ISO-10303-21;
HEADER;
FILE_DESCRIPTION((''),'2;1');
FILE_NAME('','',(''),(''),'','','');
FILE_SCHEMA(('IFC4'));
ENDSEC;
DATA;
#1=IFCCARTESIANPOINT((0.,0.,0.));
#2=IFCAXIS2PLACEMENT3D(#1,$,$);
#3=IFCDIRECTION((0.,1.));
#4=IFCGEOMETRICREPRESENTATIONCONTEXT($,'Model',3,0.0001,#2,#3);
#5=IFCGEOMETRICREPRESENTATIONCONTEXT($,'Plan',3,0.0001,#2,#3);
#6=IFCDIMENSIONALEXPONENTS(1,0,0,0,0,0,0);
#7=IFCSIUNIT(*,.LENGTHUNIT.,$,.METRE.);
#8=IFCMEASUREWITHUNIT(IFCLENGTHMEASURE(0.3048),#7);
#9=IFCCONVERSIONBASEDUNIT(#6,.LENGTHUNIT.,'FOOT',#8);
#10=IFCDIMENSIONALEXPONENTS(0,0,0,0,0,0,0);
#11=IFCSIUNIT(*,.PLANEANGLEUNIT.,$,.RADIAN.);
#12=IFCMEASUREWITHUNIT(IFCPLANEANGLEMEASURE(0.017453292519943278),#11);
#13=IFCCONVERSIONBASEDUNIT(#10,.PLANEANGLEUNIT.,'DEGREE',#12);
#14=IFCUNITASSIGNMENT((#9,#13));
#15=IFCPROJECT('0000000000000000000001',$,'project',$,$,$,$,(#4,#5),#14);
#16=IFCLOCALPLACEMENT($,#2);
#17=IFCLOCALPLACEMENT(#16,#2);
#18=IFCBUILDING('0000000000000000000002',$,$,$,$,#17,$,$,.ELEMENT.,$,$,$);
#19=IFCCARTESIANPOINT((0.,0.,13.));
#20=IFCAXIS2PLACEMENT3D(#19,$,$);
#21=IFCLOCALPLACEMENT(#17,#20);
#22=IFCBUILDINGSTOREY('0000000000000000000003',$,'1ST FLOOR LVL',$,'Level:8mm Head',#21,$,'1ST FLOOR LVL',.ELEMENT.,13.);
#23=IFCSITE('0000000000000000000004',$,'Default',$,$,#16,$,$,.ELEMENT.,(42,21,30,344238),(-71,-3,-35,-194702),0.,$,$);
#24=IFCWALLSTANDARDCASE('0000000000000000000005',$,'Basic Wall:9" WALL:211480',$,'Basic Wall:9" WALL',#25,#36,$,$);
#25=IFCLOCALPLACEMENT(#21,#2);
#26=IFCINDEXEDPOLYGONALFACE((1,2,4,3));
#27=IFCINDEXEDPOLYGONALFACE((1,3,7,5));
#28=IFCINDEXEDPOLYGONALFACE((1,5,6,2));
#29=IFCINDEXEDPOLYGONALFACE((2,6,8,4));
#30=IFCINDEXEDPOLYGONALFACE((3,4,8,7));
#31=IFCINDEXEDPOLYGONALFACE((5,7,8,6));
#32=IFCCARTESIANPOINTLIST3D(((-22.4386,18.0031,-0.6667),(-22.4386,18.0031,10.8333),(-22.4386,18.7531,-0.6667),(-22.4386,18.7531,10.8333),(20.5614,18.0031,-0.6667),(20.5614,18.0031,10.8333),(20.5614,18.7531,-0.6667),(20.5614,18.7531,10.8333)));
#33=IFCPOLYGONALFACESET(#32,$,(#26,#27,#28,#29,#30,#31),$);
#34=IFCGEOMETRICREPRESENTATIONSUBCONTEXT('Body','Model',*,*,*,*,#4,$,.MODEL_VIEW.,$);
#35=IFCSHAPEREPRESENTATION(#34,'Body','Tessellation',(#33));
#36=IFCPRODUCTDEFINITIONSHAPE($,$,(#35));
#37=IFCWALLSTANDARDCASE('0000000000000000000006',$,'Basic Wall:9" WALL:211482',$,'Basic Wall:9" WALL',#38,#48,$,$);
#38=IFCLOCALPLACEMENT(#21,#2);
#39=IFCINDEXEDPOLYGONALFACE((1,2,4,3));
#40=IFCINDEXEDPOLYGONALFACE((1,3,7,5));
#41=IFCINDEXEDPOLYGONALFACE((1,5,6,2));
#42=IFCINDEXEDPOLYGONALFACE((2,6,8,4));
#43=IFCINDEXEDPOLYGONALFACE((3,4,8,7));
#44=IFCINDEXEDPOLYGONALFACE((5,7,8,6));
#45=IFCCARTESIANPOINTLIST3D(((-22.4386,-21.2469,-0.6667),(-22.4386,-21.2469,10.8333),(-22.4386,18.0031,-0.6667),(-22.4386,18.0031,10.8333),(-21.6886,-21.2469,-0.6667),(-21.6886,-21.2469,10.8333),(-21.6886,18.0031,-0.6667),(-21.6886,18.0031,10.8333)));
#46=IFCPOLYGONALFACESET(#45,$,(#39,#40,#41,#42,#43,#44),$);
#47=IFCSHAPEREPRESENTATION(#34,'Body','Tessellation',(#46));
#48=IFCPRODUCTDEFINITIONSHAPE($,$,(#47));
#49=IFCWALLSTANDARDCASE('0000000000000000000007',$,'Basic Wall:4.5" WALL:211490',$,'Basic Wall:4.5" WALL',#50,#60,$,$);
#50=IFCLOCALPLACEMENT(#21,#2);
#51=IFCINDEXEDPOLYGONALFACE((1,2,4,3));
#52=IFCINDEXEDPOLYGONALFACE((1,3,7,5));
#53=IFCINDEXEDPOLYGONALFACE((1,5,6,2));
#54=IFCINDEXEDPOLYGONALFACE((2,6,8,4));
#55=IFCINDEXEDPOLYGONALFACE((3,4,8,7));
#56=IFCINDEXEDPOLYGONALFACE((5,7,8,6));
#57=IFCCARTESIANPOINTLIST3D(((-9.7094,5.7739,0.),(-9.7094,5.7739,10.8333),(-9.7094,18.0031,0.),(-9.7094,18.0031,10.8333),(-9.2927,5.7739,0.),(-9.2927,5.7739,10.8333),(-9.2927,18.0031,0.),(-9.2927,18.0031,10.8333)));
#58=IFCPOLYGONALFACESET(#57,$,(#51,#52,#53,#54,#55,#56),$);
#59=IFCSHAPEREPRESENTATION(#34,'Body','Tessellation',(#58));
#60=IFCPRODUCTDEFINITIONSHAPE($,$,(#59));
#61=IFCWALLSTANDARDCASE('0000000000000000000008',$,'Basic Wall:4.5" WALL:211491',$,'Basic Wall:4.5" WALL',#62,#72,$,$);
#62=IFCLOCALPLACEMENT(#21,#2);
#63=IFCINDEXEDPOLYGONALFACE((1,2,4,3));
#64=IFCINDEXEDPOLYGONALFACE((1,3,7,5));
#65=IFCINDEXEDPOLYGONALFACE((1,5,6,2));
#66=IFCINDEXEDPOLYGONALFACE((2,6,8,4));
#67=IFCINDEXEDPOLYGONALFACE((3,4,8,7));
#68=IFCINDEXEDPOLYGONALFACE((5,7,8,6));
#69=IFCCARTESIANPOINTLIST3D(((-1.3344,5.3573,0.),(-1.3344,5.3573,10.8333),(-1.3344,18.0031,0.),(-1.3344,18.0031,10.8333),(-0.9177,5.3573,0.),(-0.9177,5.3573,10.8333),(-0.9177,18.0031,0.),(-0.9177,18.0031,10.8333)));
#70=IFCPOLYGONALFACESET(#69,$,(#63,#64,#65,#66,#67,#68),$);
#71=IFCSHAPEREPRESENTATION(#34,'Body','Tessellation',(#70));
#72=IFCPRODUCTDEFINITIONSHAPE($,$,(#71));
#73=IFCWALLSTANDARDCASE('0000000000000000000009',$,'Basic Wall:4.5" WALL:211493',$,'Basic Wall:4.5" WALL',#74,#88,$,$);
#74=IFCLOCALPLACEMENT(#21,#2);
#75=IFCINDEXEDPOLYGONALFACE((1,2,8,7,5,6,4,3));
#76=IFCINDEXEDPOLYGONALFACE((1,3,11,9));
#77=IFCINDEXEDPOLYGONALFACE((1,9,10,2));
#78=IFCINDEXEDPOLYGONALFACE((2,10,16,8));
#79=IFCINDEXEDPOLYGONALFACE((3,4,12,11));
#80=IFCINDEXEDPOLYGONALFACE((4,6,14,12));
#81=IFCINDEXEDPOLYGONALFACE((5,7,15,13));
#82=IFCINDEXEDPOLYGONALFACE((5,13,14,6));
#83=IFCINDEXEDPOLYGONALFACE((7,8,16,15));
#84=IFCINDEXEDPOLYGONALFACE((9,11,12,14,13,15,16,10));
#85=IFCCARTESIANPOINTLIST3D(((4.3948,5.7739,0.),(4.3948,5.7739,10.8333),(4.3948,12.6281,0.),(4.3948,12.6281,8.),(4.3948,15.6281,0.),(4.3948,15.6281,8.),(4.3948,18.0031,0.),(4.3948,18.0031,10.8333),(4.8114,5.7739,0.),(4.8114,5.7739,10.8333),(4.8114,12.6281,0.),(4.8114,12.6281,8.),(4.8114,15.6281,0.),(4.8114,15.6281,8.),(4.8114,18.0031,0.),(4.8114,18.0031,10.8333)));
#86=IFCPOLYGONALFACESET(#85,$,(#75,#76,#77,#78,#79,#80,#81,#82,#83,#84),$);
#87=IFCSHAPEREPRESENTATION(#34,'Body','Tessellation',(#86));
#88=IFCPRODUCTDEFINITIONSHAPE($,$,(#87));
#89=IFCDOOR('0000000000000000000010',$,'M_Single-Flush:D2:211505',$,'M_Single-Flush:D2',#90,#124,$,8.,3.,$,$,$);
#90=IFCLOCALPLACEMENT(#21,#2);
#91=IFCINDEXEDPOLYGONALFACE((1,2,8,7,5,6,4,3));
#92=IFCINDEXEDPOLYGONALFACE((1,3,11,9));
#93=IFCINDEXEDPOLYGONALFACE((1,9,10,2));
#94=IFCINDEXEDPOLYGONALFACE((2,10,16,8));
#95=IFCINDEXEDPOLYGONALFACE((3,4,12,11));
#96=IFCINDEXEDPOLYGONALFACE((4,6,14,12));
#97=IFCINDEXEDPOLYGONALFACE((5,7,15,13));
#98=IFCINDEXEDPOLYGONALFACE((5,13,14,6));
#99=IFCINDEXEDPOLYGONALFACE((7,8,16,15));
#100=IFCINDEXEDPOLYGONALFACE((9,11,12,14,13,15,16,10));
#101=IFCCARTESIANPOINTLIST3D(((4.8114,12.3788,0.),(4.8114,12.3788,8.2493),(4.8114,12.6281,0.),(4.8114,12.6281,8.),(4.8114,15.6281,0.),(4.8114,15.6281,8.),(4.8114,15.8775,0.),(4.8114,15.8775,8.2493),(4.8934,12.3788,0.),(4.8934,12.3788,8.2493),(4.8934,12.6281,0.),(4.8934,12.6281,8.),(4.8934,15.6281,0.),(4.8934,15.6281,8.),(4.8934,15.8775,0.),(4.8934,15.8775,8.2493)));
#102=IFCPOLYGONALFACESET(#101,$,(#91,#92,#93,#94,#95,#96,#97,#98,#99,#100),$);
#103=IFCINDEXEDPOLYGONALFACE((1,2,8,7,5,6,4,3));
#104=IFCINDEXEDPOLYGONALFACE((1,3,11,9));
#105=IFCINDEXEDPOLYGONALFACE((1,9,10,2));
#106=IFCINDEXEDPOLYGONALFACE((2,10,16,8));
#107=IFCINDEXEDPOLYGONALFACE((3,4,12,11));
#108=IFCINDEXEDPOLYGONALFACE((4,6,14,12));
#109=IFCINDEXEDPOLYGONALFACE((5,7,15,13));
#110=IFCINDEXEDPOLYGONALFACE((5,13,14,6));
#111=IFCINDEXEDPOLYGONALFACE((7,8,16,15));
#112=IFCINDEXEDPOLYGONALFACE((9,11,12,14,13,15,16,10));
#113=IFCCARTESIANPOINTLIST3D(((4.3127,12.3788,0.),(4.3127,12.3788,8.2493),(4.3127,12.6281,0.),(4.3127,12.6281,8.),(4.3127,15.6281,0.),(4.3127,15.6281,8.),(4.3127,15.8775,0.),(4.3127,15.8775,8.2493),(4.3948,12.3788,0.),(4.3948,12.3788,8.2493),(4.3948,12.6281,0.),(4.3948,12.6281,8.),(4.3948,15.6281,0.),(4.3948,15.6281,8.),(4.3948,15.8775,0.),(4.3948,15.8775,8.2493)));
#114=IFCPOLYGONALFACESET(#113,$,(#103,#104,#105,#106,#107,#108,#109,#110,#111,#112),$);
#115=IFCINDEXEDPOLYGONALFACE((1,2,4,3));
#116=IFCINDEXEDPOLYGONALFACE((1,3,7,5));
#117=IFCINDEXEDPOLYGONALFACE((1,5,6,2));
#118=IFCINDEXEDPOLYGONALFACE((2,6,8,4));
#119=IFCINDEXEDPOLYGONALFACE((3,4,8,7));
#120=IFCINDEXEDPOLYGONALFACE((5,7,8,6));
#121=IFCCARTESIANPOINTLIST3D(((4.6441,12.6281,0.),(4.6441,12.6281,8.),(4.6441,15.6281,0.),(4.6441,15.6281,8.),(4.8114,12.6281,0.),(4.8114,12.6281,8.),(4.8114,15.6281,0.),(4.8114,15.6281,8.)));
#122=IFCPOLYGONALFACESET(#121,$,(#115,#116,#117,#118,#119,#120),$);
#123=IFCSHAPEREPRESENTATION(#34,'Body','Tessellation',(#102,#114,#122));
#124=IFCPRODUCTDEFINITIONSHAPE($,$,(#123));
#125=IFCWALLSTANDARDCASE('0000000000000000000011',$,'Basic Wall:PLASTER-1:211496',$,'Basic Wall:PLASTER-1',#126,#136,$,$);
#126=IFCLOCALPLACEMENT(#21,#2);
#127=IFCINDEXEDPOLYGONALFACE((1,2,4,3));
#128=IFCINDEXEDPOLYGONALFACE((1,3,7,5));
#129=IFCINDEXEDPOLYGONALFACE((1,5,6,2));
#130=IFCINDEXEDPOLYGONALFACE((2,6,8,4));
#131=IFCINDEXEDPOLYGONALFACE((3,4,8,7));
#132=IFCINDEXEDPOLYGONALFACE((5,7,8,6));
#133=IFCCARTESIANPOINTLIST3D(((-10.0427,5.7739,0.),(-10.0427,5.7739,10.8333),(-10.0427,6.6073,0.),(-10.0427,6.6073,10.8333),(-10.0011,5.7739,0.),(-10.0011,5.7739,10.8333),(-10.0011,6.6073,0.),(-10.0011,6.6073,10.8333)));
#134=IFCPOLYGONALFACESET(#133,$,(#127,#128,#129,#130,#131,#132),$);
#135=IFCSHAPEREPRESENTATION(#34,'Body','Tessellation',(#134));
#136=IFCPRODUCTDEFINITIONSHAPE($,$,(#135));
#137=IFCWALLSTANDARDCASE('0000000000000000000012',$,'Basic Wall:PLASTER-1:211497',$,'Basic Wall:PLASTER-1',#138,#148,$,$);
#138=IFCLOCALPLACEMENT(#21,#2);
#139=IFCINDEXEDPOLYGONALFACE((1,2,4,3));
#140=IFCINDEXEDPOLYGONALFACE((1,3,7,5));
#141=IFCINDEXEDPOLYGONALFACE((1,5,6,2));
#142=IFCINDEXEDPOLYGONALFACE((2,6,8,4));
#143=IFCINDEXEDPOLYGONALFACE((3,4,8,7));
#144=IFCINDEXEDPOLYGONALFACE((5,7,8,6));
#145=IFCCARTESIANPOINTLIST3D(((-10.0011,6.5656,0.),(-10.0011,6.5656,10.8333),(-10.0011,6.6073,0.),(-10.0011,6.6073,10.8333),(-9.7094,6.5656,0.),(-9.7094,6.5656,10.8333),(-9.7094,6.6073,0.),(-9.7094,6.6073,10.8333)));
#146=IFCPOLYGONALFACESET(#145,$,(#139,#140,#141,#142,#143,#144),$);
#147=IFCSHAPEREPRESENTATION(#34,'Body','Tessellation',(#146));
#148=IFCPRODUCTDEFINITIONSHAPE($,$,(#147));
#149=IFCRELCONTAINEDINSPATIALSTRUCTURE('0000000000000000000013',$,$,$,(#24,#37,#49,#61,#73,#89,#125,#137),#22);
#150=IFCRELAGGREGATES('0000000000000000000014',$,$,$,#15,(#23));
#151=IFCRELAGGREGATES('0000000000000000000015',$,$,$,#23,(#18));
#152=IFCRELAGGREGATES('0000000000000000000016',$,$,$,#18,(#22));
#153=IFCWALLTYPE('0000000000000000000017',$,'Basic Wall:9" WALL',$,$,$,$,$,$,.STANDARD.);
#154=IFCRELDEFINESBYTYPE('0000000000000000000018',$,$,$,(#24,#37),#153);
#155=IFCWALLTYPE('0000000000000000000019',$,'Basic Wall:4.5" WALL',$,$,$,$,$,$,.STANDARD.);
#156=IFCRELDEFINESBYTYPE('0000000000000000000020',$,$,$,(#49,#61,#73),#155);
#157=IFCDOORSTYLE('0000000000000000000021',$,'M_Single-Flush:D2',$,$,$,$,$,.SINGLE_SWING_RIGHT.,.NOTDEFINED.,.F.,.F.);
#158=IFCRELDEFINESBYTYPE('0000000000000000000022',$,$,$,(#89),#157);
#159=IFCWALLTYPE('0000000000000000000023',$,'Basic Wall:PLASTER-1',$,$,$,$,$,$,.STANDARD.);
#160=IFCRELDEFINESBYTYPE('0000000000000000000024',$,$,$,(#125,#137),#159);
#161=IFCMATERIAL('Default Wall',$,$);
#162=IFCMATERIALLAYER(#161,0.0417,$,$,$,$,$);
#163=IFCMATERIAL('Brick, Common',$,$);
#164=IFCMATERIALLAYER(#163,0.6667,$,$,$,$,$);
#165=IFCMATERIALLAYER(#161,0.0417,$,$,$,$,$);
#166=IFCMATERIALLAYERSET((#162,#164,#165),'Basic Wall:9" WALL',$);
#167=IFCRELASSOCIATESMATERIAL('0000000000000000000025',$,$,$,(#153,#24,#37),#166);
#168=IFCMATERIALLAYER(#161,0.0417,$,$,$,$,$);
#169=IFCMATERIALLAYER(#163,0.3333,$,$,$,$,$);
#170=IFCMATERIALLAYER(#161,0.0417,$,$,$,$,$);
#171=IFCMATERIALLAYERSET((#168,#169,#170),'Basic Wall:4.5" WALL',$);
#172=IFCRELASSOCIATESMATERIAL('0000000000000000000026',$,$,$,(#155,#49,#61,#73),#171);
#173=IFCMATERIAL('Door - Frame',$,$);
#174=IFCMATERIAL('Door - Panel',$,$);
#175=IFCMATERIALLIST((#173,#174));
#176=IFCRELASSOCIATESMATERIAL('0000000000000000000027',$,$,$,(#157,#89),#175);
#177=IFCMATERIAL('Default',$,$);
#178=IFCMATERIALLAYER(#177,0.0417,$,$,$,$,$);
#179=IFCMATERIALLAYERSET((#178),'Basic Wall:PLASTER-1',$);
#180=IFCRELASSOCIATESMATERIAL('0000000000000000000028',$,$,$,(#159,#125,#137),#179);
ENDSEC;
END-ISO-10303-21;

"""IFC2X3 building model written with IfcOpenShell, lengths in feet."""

from ifc_helpers import new_model, entity, si_unit, converted_unit, direction, frame, frame_2d, origin, place, context, subcontext, project, spatial, polyline, rectangle, outline, extrude, source, transform, mapped, material, material_list, layer, layer_set, layer_usage, type_object, type_shapes, element, fill, save


model = new_model("IFC2X3")

# Units and contexts
model_context = context("Model", 3, precision=0.0001, world=origin(), true_north=direction((0.0, 1.0)))
plan_context = context("Plan", 3, precision=0.0001, world=origin(), true_north=direction((0.0, 1.0)))
body_context = subcontext(model_context, "Body", "Model", "MODEL_VIEW")
ifc_project = project(units=[converted_unit("LENGTHUNIT", "FOOT", entity("IfcLengthMeasure", 0.3048), si_unit("LENGTHUNIT", "METRE"), dimensions=[1, 0, 0, 0, 0, 0, 0]), converted_unit("PLANEANGLEUNIT", "DEGREE", entity("IfcPlaneAngleMeasure", 0.017453292519943278), si_unit("PLANEANGLEUNIT", "RADIAN"), dimensions=[0, 0, 0, 0, 0, 0, 0])], contexts=[model_context, plan_context])

# Site, building, storey
site_placement = place(None, origin())
site = spatial("IfcSite", under=ifc_project, at=site_placement, Name="Default", CompositionType="ELEMENT", RefLatitude=(42, 21, 30, 344238), RefLongitude=(-71, -3, -35, -194702), RefElevation=0.0)
building_placement = place(site_placement, origin())
building = spatial("IfcBuilding", under=site, at=building_placement, CompositionType="ELEMENT")
storey_placement = place(building_placement, frame((0.0, 0.0, 13.0)))
storey = spatial("IfcBuildingStorey", under=building, at=storey_placement, Name="1ST FLOOR LVL", ObjectType="Level:8mm Head", LongName="1ST FLOOR LVL", CompositionType="ELEMENT", Elevation=13.0)

# Wall
ifc_material_1 = material(Name="Default Wall")
ifc_layer_1 = layer(ifc_material_1, 0.0417)
ifc_material_2 = material(Name="Brick, Common")
ifc_layer_2 = layer(ifc_material_2, 0.6667)
ifc_layer_3 = layer(ifc_material_1, 0.0417)
ifc_layer_set_1 = layer_set([ifc_layer_1, ifc_layer_2, ifc_layer_3], Name="Basic Wall:9\" WALL")
ifc_layer_usage_1 = layer_usage(ifc_layer_set_1, "AXIS2", "NEGATIVE", 0.375)
wall_type_1 = type_object("IfcWallType", Name="Basic Wall:9\" WALL", PredefinedType="STANDARD", material=ifc_layer_set_1)
wall_1_placement = place(storey_placement, frame((-22.4386, 18.3781, -0.6667)))
element("IfcWallStandardCase", 1, at=wall_1_placement, inside=storey, type_object=wall_type_1, material=ifc_layer_usage_1, Name="Basic Wall:9\" WALL:211480", ObjectType="Basic Wall:9\" WALL", context=body_context, shape_type="SweptSolid", body=[
    extrude(rectangle(XDim=43.0, YDim=0.75, at=frame_2d((21.5, 0.0), x_axis=(-1.0, 0.0))), origin(), (0.0, 0.0, 1.0), 11.5),
])

# Wall
ifc_layer_usage_2 = layer_usage(ifc_layer_set_1, "AXIS2", "NEGATIVE", 0.375)
wall_2_placement = place(storey_placement, frame((-22.0636, 18.0031, -0.6667), z_axis=(0.0, 0.0, 1.0), x_axis=(0.0, -1.0, 0.0)))
element("IfcWallStandardCase", 2, at=wall_2_placement, inside=storey, type_object=wall_type_1, material=ifc_layer_usage_2, Name="Basic Wall:9\" WALL:211482", ObjectType="Basic Wall:9\" WALL", context=body_context, shape_type="SweptSolid", body=[
    extrude(rectangle(XDim=39.25, YDim=0.75, at=frame_2d((19.625, 0.0), x_axis=(-1.0, 0.0))), origin(), (0.0, 0.0, 1.0), 11.5),
])

# Shared definitions
ifc_layer_4 = layer(ifc_material_1, 0.0417)
ifc_layer_5 = layer(ifc_material_2, 0.3333)
ifc_layer_6 = layer(ifc_material_1, 0.0417)
ifc_layer_set_2 = layer_set([ifc_layer_4, ifc_layer_5, ifc_layer_6], Name="Basic Wall:4.5\" WALL")
wall_type_2 = type_object("IfcWallType", Name="Basic Wall:4.5\" WALL", PredefinedType="STANDARD", material=ifc_layer_set_2)
ifc_material_3 = material(Name="Door - Frame")
ifc_material_4 = material(Name="Door - Panel")
ifc_material_list_1 = material_list([ifc_material_3, ifc_material_4])

# Walls
ifc_layer_usage_3 = layer_usage(ifc_layer_set_2, "AXIS2", "NEGATIVE", 0.2083)
wall_3_placement = place(storey_placement, frame((-9.5011, 18.0031, 0.0), z_axis=(0.0, 0.0, 1.0), x_axis=(0.0, -1.0, 0.0)))
element("IfcWallStandardCase", 3, at=wall_3_placement, inside=storey, type_object=wall_type_2, material=ifc_layer_usage_3, Name="Basic Wall:4.5\" WALL:211490", ObjectType="Basic Wall:4.5\" WALL", context=body_context, shape_type="SweptSolid", body=[
    extrude(rectangle(XDim=12.2292, YDim=0.4167, at=frame_2d((6.1146, 0.0), x_axis=(-1.0, 0.0))), origin(), (0.0, 0.0, 1.0), 10.8333),
])
ifc_layer_usage_4 = layer_usage(ifc_layer_set_2, "AXIS2", "NEGATIVE", 0.2083)
wall_4_placement = place(storey_placement, frame((-1.1261, 18.0031, 0.0), z_axis=(0.0, 0.0, 1.0), x_axis=(0.0, -1.0, 0.0)))
element("IfcWallStandardCase", 4, at=wall_4_placement, inside=storey, type_object=wall_type_2, material=ifc_layer_usage_4, Name="Basic Wall:4.5\" WALL:211491", ObjectType="Basic Wall:4.5\" WALL", context=body_context, shape_type="SweptSolid", body=[
    extrude(rectangle(XDim=12.6458, YDim=0.4167, at=frame_2d((6.3229, 0.0), x_axis=(-1.0, 0.0))), origin(), (0.0, 0.0, 1.0), 10.8333),
])

# Wall, opening, door
ifc_layer_usage_5 = layer_usage(ifc_layer_set_2, "AXIS2", "NEGATIVE", 0.2083)
wall_5_placement = place(storey_placement, frame((4.6031, 5.7739, 0.0), z_axis=(0.0, 0.0, 1.0), x_axis=(0.0, 1.0, 0.0)))
wall_5 = element("IfcWallStandardCase", 5, at=wall_5_placement, inside=storey, type_object=wall_type_2, material=ifc_layer_usage_5, Name="Basic Wall:4.5\" WALL:211493", ObjectType="Basic Wall:4.5\" WALL", context=body_context, shape_type="SweptSolid", body=[
    extrude(rectangle(XDim=12.2292, YDim=0.4167, at=frame_2d((6.1146, 0.0), x_axis=(1.0, 0.0))), origin(), (0.0, 0.0, 1.0), 10.8333),
])
opening_1_placement = place(wall_5_placement, frame((9.8542, 0.2083, 0.0)))
opening_1 = element("IfcOpeningElement", 6, at=opening_1_placement, cuts=wall_5, ObjectType="Opening", context=body_context, shape_type="SweptSolid", body=[
    extrude(rectangle(XDim=3.0, YDim=8.0, at=frame_2d((4.0, 1.5), x_axis=(0.0, 1.0))), frame((0.0, 0.0, 0.0), z_axis=(0.0, -1.0, 0.0), x_axis=(0.0, 0.0, 1.0)), (0.0, 0.0, 1.0), 0.4167),
])
door_style_1 = type_object("IfcDoorStyle", Name="M_Single-Flush:D2", ConstructionType="NOTDEFINED", OperationType="SINGLE_SWING_RIGHT", ParameterTakesPrecedence=False, Sizeable=False, material=ifc_material_list_1)
shared_shape_1 = source(origin(), body_context, "Body", "SweptSolid", [
    extrude(outline(polyline([(-1.7493, -4.187), (1.7493, -4.187), (1.7493, 4.0623), (1.5, 4.0623), (1.5, -3.9377), (-1.5, -3.9377), (-1.5, 4.0623), (-1.7493, 4.0623), (-1.7493, -4.187)])), frame((1.5, 0.4167, 4.0623), z_axis=(0.0, 1.0, 0.0), x_axis=(1.0, 0.0, 0.0)), (0.0, 0.0, 1.0), 0.082),
    extrude(outline(polyline([(-4.187, -1.7493), (4.0623, -1.7493), (4.0623, -1.5), (-3.9377, -1.5), (-3.9377, 1.5), (4.0623, 1.5), (4.0623, 1.7493), (-4.187, 1.7493), (-4.187, -1.7493)])), frame((1.5, -0.082, 4.0623), z_axis=(0.0, 1.0, 0.0), x_axis=(0.0, 0.0, -1.0)), (0.0, 0.0, 1.0), 0.082),
    extrude(rectangle(XDim=0.1673, YDim=3.0, at=frame_2d((0.0, 0.0), x_axis=(1.0, 0.0))), frame((1.5, 0.333, 0.0), z_axis=(0.0, 0.0, 1.0), x_axis=(0.0, 1.0, 0.0)), (0.0, 0.0, 1.0), 8.0),
])
type_shapes(door_style_1, [shared_shape_1])
door_1_placement = place(opening_1_placement, frame((0.0, 0.0, 0.0), z_axis=(0.0, 0.0, 1.0), x_axis=(-1.0, 0.0, 0.0)))
door_1 = element("IfcDoor", 7, at=door_1_placement, inside=storey, type_object=door_style_1, material=ifc_material_list_1, Name="M_Single-Flush:D2:211505", ObjectType="M_Single-Flush:D2", OverallHeight=8.0, OverallWidth=3.0, context=body_context, shape_type="MappedRepresentation", body=[
    mapped(shared_shape_1, transform((0.0, 0.0, 0.0), scale=1.0)),
])
fill(opening_1, door_1)

# Walls
ifc_material_5 = material(Name="Default")
ifc_layer_7 = layer(ifc_material_5, 0.0417)
ifc_layer_set_3 = layer_set([ifc_layer_7], Name="Basic Wall:PLASTER-1")
ifc_layer_usage_6 = layer_usage(ifc_layer_set_3, "AXIS2", "NEGATIVE", 0.0208)
wall_type_3 = type_object("IfcWallType", Name="Basic Wall:PLASTER-1", PredefinedType="STANDARD", material=ifc_layer_set_3)
wall_6_placement = place(storey_placement, frame((-10.0219, 5.7739, 0.0), z_axis=(0.0, 0.0, 1.0), x_axis=(0.0, 1.0, 0.0)))
element("IfcWallStandardCase", 8, at=wall_6_placement, inside=storey, type_object=wall_type_3, material=ifc_layer_usage_6, Name="Basic Wall:PLASTER-1:211496", ObjectType="Basic Wall:PLASTER-1", context=body_context, shape_type="SweptSolid", body=[
    extrude(rectangle(XDim=0.8333, YDim=0.0417, at=frame_2d((0.4167, 0.0), x_axis=(-1.0, 0.0))), origin(), (0.0, 0.0, 1.0), 10.8333),
])
ifc_layer_usage_7 = layer_usage(ifc_layer_set_3, "AXIS2", "NEGATIVE", 0.0208)
wall_7_placement = place(storey_placement, frame((-10.0011, 6.5864, 0.0)))
element("IfcWallStandardCase", 9, at=wall_7_placement, inside=storey, type_object=wall_type_3, material=ifc_layer_usage_7, Name="Basic Wall:PLASTER-1:211497", ObjectType="Basic Wall:PLASTER-1", context=body_context, shape_type="SweptSolid", body=[
    extrude(rectangle(XDim=0.2917, YDim=0.0417, at=frame_2d((0.1458, 0.0), x_axis=(-1.0, 0.0))), origin(), (0.0, 0.0, 1.0), 10.8333),
])

save(model, "model.ifc")
